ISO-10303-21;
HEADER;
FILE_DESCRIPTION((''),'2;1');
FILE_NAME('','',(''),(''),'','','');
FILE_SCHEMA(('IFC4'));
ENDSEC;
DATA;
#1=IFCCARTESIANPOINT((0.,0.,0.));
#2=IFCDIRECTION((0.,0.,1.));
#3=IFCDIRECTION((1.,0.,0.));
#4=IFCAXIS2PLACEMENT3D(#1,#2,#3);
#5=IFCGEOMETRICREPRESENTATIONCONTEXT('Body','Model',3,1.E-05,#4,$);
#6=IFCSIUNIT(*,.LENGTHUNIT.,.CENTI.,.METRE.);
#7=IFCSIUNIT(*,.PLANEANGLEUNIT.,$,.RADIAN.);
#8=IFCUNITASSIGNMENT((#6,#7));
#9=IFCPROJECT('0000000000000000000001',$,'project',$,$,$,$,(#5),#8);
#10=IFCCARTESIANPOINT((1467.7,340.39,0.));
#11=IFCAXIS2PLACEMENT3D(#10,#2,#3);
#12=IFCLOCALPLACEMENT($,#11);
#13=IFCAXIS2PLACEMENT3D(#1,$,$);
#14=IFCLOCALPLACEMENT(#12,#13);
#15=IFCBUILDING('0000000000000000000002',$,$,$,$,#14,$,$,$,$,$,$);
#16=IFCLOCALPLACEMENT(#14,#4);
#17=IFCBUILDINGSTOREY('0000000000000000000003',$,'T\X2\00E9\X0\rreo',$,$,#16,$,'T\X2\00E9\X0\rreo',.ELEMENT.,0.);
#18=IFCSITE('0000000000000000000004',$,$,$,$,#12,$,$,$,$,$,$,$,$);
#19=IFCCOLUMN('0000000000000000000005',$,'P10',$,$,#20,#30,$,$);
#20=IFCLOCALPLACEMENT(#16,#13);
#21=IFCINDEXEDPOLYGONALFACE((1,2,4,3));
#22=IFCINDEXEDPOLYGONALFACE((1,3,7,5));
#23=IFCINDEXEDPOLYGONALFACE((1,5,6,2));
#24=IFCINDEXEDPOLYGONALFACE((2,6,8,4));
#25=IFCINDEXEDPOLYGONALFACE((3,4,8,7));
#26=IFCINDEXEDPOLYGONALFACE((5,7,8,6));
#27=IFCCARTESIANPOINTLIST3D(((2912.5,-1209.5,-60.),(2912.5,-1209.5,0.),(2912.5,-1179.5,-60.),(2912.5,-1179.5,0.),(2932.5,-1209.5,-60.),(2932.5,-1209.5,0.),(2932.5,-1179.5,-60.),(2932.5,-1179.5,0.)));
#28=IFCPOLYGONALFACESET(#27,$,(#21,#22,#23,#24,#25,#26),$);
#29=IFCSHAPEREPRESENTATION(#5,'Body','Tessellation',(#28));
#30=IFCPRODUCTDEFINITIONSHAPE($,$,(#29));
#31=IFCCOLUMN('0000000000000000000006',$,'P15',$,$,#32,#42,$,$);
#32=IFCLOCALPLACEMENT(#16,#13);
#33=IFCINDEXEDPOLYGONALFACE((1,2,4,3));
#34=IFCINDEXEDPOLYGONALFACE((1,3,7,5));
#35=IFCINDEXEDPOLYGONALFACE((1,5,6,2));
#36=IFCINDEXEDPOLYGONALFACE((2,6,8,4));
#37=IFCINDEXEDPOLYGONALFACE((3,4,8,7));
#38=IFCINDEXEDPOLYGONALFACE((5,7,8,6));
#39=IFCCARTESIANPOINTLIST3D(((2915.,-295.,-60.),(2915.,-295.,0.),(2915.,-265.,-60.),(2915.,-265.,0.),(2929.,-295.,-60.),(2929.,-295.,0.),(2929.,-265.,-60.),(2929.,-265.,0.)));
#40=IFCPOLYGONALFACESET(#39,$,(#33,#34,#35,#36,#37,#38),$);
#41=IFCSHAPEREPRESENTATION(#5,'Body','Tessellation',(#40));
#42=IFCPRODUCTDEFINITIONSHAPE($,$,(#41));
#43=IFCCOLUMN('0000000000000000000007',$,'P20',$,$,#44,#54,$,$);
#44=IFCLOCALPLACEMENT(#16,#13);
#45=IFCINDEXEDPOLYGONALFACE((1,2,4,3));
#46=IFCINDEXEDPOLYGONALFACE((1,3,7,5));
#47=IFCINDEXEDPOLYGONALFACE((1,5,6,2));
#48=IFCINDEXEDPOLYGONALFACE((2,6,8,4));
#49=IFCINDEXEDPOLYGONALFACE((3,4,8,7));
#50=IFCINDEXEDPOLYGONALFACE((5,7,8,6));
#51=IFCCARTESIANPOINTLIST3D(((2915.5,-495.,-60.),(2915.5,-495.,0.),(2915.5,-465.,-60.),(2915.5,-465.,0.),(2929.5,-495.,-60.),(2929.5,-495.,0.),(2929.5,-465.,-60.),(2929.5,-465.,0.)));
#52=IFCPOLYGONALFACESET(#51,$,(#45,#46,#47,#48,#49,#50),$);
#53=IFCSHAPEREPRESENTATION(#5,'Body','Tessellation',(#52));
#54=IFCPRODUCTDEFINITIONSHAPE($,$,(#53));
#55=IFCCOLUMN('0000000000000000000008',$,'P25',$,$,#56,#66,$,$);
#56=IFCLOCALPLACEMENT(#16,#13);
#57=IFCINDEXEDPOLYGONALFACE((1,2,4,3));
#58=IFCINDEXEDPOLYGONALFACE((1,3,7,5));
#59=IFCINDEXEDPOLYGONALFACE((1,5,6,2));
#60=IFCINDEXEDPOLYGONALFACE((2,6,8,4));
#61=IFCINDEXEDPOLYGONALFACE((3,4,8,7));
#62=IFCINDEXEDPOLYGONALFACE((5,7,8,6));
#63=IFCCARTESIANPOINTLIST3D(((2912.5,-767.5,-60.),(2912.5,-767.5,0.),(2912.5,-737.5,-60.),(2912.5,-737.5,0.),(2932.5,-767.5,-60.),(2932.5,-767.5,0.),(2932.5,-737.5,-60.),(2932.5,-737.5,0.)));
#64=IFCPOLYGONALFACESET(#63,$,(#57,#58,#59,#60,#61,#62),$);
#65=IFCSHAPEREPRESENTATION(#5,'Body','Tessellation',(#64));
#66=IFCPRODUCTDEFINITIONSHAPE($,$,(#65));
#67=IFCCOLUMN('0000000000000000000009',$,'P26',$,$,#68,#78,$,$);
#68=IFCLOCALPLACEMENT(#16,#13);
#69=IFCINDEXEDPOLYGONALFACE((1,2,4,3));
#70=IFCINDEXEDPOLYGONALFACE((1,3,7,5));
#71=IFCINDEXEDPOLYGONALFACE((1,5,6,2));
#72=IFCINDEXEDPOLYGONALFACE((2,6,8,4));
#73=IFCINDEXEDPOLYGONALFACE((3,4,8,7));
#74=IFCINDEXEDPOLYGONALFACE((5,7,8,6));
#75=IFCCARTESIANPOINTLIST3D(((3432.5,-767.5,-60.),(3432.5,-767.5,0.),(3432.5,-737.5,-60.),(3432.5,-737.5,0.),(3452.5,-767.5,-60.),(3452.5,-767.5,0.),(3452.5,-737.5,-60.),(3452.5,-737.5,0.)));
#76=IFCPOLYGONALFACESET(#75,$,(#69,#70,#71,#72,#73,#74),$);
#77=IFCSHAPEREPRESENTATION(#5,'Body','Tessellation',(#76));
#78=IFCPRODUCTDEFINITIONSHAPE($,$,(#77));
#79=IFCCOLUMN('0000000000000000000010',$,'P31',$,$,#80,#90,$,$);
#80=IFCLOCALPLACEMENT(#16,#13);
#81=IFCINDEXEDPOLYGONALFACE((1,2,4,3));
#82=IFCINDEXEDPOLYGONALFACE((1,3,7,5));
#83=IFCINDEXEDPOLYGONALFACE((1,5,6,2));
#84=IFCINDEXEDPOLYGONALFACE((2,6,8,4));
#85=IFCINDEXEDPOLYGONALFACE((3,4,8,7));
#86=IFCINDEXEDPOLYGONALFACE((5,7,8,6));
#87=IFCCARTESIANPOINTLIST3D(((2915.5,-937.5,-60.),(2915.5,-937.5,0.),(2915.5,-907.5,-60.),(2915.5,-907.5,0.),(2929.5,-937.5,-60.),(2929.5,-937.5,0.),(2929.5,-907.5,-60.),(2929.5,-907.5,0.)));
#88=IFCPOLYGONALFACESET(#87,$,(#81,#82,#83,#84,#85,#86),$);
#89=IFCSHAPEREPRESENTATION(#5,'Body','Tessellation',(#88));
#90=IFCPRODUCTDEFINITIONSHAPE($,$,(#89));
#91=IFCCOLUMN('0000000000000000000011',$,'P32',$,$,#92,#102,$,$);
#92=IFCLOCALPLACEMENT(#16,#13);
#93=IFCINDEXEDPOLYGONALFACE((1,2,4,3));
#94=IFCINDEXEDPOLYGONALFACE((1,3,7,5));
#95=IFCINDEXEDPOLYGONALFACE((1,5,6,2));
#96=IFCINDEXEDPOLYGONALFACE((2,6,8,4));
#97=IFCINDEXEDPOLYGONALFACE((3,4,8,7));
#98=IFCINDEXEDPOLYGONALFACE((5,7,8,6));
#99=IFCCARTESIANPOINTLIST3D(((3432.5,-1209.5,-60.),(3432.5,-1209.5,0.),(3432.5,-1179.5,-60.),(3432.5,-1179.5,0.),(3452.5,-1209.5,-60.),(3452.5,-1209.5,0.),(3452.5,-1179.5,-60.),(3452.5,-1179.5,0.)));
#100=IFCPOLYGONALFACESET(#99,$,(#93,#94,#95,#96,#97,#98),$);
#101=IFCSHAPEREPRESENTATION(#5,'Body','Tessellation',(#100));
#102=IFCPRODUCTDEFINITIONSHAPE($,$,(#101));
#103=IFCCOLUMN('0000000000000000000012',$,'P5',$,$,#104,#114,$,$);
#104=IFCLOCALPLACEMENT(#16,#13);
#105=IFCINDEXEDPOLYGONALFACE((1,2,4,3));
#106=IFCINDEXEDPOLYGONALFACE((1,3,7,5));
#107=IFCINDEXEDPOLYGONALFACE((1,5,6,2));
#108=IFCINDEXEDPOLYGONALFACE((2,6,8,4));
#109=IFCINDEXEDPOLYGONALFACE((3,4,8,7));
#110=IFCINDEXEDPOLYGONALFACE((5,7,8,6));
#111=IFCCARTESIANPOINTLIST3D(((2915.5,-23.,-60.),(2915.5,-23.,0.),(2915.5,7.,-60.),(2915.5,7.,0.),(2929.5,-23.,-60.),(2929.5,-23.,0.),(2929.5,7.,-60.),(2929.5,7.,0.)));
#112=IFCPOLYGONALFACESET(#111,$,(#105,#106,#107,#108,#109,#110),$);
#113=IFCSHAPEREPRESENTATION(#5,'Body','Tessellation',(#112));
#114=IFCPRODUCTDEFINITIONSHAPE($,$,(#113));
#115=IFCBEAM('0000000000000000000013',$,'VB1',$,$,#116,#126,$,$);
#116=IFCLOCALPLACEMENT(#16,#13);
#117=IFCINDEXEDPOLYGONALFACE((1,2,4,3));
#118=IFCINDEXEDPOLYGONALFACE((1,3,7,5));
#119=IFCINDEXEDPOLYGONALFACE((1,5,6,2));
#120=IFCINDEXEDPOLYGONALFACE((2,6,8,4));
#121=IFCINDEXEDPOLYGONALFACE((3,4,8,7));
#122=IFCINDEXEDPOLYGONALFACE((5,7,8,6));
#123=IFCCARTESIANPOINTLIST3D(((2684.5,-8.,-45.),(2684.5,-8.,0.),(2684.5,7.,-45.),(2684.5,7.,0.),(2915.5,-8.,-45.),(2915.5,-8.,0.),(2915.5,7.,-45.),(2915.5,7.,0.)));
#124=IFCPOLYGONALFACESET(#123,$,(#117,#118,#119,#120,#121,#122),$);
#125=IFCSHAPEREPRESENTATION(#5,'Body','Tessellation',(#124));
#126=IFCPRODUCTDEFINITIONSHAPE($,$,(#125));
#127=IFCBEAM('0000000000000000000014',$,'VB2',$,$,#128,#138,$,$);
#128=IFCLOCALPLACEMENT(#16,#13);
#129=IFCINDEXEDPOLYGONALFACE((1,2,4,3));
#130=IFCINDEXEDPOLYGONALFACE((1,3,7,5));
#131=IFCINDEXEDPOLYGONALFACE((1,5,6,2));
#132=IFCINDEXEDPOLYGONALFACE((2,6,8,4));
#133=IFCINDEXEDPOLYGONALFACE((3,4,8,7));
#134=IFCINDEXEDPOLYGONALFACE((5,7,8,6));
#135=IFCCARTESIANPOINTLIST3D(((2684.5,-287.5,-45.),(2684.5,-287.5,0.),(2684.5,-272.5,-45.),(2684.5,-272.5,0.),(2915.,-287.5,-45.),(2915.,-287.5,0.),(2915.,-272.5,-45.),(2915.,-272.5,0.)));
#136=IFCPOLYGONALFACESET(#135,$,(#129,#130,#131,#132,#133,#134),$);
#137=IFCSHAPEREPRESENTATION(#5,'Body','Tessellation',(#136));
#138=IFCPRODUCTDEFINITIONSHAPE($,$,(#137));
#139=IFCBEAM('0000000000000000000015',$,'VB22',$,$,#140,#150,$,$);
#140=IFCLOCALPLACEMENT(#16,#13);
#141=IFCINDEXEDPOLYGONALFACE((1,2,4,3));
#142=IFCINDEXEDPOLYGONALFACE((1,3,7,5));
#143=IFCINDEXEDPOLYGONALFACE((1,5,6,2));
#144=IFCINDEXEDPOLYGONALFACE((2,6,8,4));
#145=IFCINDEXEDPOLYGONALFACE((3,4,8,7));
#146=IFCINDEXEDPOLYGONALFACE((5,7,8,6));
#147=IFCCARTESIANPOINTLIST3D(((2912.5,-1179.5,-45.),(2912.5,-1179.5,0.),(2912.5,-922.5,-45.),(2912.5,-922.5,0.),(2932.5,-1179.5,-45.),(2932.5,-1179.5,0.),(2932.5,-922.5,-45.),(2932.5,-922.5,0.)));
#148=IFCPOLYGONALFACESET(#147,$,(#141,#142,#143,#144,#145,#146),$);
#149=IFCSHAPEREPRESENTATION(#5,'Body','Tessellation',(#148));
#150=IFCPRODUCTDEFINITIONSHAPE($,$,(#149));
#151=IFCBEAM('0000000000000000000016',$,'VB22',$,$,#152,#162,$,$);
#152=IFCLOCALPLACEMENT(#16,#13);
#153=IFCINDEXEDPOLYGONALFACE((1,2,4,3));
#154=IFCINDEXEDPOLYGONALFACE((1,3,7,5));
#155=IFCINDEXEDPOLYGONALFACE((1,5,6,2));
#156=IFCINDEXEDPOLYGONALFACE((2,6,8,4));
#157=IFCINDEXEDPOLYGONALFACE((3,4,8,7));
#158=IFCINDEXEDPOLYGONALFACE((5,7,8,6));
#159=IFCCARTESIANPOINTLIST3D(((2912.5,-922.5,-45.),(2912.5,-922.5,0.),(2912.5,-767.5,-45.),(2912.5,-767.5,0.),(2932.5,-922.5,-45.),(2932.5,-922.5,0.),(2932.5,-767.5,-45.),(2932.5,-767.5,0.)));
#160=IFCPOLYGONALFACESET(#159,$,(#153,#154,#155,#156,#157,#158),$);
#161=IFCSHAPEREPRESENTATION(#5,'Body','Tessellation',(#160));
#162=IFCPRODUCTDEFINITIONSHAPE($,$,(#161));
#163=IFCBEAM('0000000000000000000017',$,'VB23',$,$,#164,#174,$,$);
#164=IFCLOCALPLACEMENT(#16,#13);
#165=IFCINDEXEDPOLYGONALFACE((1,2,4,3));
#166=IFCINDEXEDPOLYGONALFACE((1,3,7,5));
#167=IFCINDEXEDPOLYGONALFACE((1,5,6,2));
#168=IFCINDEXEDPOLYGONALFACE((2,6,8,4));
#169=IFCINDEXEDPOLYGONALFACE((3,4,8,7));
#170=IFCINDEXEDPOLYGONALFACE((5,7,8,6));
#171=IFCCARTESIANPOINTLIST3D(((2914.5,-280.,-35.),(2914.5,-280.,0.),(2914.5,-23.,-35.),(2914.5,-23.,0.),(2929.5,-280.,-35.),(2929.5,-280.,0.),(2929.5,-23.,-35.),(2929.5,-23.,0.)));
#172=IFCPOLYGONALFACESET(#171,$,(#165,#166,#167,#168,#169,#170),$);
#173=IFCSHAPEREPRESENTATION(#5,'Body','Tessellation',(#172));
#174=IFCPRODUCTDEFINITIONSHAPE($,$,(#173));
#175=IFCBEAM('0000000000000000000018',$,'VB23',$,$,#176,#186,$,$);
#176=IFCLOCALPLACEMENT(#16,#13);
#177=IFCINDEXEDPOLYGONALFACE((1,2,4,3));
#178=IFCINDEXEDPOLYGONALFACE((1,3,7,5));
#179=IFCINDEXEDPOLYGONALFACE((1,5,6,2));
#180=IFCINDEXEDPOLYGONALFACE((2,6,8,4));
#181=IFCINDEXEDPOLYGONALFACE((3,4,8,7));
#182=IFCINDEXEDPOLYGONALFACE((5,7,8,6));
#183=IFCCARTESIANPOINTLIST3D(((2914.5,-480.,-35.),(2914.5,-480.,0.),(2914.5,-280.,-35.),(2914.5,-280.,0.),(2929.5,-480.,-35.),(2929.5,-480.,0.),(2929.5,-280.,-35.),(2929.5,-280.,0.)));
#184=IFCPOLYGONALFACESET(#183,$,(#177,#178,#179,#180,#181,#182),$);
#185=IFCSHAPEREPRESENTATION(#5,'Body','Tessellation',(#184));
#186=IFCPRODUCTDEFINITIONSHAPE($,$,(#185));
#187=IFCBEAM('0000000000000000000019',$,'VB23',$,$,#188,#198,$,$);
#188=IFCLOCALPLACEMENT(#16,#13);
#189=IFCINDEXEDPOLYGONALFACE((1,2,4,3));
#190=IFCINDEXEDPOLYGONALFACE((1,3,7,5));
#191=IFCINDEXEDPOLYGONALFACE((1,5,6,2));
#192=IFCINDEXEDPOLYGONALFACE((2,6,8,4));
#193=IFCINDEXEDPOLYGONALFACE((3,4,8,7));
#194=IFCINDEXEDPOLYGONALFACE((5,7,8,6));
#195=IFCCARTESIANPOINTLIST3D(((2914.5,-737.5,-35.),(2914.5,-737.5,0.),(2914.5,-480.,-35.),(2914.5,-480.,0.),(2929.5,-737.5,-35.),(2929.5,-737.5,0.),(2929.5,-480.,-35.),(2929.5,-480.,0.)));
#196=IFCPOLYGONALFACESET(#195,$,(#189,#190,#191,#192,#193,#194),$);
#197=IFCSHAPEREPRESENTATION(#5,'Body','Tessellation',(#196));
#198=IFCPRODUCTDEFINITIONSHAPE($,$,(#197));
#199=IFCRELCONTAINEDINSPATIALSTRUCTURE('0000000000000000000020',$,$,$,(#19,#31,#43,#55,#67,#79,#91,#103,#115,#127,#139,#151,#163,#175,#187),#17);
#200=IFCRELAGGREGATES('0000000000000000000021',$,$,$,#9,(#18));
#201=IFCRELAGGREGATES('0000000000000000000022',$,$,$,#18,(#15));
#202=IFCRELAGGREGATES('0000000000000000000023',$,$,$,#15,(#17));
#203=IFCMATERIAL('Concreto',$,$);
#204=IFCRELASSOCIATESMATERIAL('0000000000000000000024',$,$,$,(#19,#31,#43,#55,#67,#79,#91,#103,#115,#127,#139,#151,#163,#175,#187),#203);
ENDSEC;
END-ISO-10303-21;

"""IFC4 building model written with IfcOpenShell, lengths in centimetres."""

from ifc_helpers import new_model, si_unit, frame, origin, origin_with_axes, origin_2d_with_axis, place, context, project, spatial, rectangle, extrude, material, element, save


model = new_model("IFC4")

# Units and contexts
model_context = context("Model", 3, precision=1e-05, world=origin_with_axes(), identifier="Body")
ifc_project = project(units=[si_unit("LENGTHUNIT", "METRE", prefix="CENTI"), si_unit("PLANEANGLEUNIT", "RADIAN")], contexts=[model_context])

# Site, building, storey
site_placement = place(None, frame((1467.7, 340.39, 0.0), z_axis=(0.0, 0.0, 1.0), x_axis=(1.0, 0.0, 0.0)))
site = spatial("IfcSite", under=ifc_project, at=site_placement)
building_placement = place(site_placement, origin())
building = spatial("IfcBuilding", under=site, at=building_placement)
storey_placement = place(building_placement, origin_with_axes())
storey = spatial("IfcBuildingStorey", under=building, at=storey_placement, Name="Térreo", LongName="Térreo", CompositionType="ELEMENT", Elevation=0.0)

# Columns
ifc_material = material(Name="Concreto")
column_1_placement = place(storey_placement, frame((2922.5, -1194.5, 0.0), z_axis=(0.0, 0.0, 1.0), x_axis=(1.0, 0.0, 0.0)))
element("IfcColumn", 1, at=column_1_placement, inside=storey, material=ifc_material, Name="P10", context=model_context, shape_type="SolidModel", body=[
    extrude(rectangle(XDim=20.0, YDim=30.0, at=origin_2d_with_axis()), frame((0.0, 0.0, -60.0), z_axis=(0.0, 0.0, 1.0), x_axis=(1.0, 0.0, 0.0)), (0.0, 0.0, 1.0), 60.0),
])
for number, where, z_axis, x_axis, name in (
    (2, (2922.0, -280.0, 0.0), (0.0, 0.0, 1.0), (1.0, 0.0, 0.0), "P15"),
    (3, (2922.5, -480.0, 0.0), (0.0, 0.0, 1.0), (1.0, 0.0, 0.0), "P20"),
):
    element("IfcColumn", number, at=place(storey_placement, frame(where, z_axis=z_axis, x_axis=x_axis)), inside=storey, material=ifc_material, Name=name, context=model_context, shape_type="SolidModel", body=[
        extrude(rectangle(XDim=14.0, YDim=30.0, at=origin_2d_with_axis()), frame((0.0, 0.0, -60.0), z_axis=(0.0, 0.0, 1.0), x_axis=(1.0, 0.0, 0.0)), (0.0, 0.0, 1.0), 60.0),
    ])
column_2_placement = place(storey_placement, frame((2922.5, -752.5, 0.0), z_axis=(0.0, 0.0, 1.0), x_axis=(1.0, 0.0, 0.0)))
element("IfcColumn", 4, at=column_2_placement, inside=storey, material=ifc_material, Name="P25", context=model_context, shape_type="SolidModel", body=[
    extrude(rectangle(XDim=20.0, YDim=30.0, at=origin_2d_with_axis()), frame((0.0, 0.0, -60.0), z_axis=(0.0, 0.0, 1.0), x_axis=(-1.0, 0.0, 0.0)), (0.0, 0.0, 1.0), 60.0),
])
column_3_placement = place(storey_placement, frame((3442.5, -752.5, 0.0), z_axis=(0.0, 0.0, 1.0), x_axis=(1.0, 0.0, 0.0)))
element("IfcColumn", 5, at=column_3_placement, inside=storey, material=ifc_material, Name="P26", context=model_context, shape_type="SolidModel", body=[
    extrude(rectangle(XDim=20.0, YDim=30.0, at=origin_2d_with_axis()), frame((0.0, 0.0, -60.0), z_axis=(0.0, 0.0, 1.0), x_axis=(1.0, 0.0, 0.0)), (0.0, 0.0, 1.0), 60.0),
])
column_4_placement = place(storey_placement, frame((2922.5, -922.5, 0.0), z_axis=(0.0, 0.0, 1.0), x_axis=(1.0, 0.0, 0.0)))
element("IfcColumn", 6, at=column_4_placement, inside=storey, material=ifc_material, Name="P31", context=model_context, shape_type="SolidModel", body=[
    extrude(rectangle(XDim=14.0, YDim=30.0, at=origin_2d_with_axis()), frame((0.0, 0.0, -60.0), z_axis=(0.0, 0.0, 1.0), x_axis=(1.0, 0.0, 0.0)), (0.0, 0.0, 1.0), 60.0),
])
column_5_placement = place(storey_placement, frame((3442.5, -1194.5, 0.0), z_axis=(0.0, 0.0, 1.0), x_axis=(1.0, 0.0, 0.0)))
element("IfcColumn", 7, at=column_5_placement, inside=storey, material=ifc_material, Name="P32", context=model_context, shape_type="SolidModel", body=[
    extrude(rectangle(XDim=20.0, YDim=30.0, at=origin_2d_with_axis()), frame((0.0, 0.0, -60.0), z_axis=(0.0, 0.0, 1.0), x_axis=(1.0, 0.0, 0.0)), (0.0, 0.0, 1.0), 60.0),
])
column_6_placement = place(storey_placement, frame((2922.5, -8.0, 0.0), z_axis=(0.0, 0.0, 1.0), x_axis=(1.0, 0.0, 0.0)))
element("IfcColumn", 8, at=column_6_placement, inside=storey, material=ifc_material, Name="P5", context=model_context, shape_type="SolidModel", body=[
    extrude(rectangle(XDim=14.0, YDim=30.0, at=origin_2d_with_axis()), frame((0.0, 0.0, -60.0), z_axis=(0.0, 0.0, 1.0), x_axis=(1.0, 0.0, 0.0)), (0.0, 0.0, 1.0), 60.0),
])

# Beams
beam_1_placement = place(storey_placement, frame((2800.0, -0.5, 0.0), z_axis=(0.0, 0.0, 1.0), x_axis=(1.0, 0.0, 0.0)))
element("IfcBeam", 9, at=beam_1_placement, inside=storey, material=ifc_material, Name="VB1", context=model_context, shape_type="SolidModel", body=[
    extrude(rectangle(XDim=15.0, YDim=45.0, at=origin_2d_with_axis()), frame((-115.5, 0.0, -22.5), z_axis=(1.0, 0.0, 0.0), x_axis=(0.0, 1.0, 0.0)), (0.0, 0.0, 1.0), 231.0),
])
beam_2_placement = place(storey_placement, frame((2799.75, -280.0, 0.0), z_axis=(0.0, 0.0, 1.0), x_axis=(1.0, 0.0, 0.0)))
element("IfcBeam", 10, at=beam_2_placement, inside=storey, material=ifc_material, Name="VB2", context=model_context, shape_type="SolidModel", body=[
    extrude(rectangle(XDim=15.0, YDim=45.0, at=origin_2d_with_axis()), frame((-115.25, 0.0, -22.5), z_axis=(1.0, 0.0, 0.0), x_axis=(0.0, 1.0, 0.0)), (0.0, 0.0, 1.0), 230.5),
])
beam_3_placement = place(storey_placement, frame((2922.5, -1051.0, 0.0), z_axis=(0.0, 0.0, 1.0), x_axis=(1.0, 0.0, 0.0)))
element("IfcBeam", 11, at=beam_3_placement, inside=storey, material=ifc_material, Name="VB22", context=model_context, shape_type="SolidModel", body=[
    extrude(rectangle(XDim=20.0, YDim=45.0, at=origin_2d_with_axis()), frame((0.0, -128.5, -22.5), z_axis=(0.0, 1.0, 0.0), x_axis=(1.0, 0.0, 0.0)), (0.0, 0.0, 1.0), 257.0),
])
beam_4_placement = place(storey_placement, frame((2922.5, -845.0, 0.0), z_axis=(0.0, 0.0, 1.0), x_axis=(1.0, 0.0, 0.0)))
element("IfcBeam", 12, at=beam_4_placement, inside=storey, material=ifc_material, Name="VB22", context=model_context, shape_type="SolidModel", body=[
    extrude(rectangle(XDim=20.0, YDim=45.0, at=origin_2d_with_axis()), frame((0.0, -77.5, -22.5), z_axis=(0.0, 1.0, 0.0), x_axis=(1.0, 0.0, 0.0)), (0.0, 0.0, 1.0), 155.0),
])
beam_5_placement = place(storey_placement, frame((2922.0, -151.5, 0.0), z_axis=(0.0, 0.0, 1.0), x_axis=(1.0, 0.0, 0.0)))
element("IfcBeam", 13, at=beam_5_placement, inside=storey, material=ifc_material, Name="VB23", context=model_context, shape_type="SolidModel", body=[
    extrude(rectangle(XDim=15.0, YDim=35.0, at=origin_2d_with_axis()), frame((0.0, -128.5, -17.5), z_axis=(0.0, 1.0, 0.0), x_axis=(1.0, 0.0, 0.0)), (0.0, 0.0, 1.0), 257.0),
])
beam_6_placement = place(storey_placement, frame((2922.0, -380.0, 0.0), z_axis=(0.0, 0.0, 1.0), x_axis=(1.0, 0.0, 0.0)))
element("IfcBeam", 14, at=beam_6_placement, inside=storey, material=ifc_material, Name="VB23", context=model_context, shape_type="SolidModel", body=[
    extrude(rectangle(XDim=15.0, YDim=35.0, at=origin_2d_with_axis()), frame((0.0, -100.0, -17.5), z_axis=(0.0, 1.0, 0.0), x_axis=(1.0, 0.0, 0.0)), (0.0, 0.0, 1.0), 200.0),
])
beam_7_placement = place(storey_placement, frame((2922.0, -608.75, 0.0), z_axis=(0.0, 0.0, 1.0), x_axis=(1.0, 0.0, 0.0)))
element("IfcBeam", 15, at=beam_7_placement, inside=storey, material=ifc_material, Name="VB23", context=model_context, shape_type="SolidModel", body=[
    extrude(rectangle(XDim=15.0, YDim=35.0, at=origin_2d_with_axis()), frame((0.0, -128.75, -17.5), z_axis=(0.0, 1.0, 0.0), x_axis=(1.0, 0.0, 0.0)), (0.0, 0.0, 1.0), 257.5),
])

save(model, "model.ifc")
